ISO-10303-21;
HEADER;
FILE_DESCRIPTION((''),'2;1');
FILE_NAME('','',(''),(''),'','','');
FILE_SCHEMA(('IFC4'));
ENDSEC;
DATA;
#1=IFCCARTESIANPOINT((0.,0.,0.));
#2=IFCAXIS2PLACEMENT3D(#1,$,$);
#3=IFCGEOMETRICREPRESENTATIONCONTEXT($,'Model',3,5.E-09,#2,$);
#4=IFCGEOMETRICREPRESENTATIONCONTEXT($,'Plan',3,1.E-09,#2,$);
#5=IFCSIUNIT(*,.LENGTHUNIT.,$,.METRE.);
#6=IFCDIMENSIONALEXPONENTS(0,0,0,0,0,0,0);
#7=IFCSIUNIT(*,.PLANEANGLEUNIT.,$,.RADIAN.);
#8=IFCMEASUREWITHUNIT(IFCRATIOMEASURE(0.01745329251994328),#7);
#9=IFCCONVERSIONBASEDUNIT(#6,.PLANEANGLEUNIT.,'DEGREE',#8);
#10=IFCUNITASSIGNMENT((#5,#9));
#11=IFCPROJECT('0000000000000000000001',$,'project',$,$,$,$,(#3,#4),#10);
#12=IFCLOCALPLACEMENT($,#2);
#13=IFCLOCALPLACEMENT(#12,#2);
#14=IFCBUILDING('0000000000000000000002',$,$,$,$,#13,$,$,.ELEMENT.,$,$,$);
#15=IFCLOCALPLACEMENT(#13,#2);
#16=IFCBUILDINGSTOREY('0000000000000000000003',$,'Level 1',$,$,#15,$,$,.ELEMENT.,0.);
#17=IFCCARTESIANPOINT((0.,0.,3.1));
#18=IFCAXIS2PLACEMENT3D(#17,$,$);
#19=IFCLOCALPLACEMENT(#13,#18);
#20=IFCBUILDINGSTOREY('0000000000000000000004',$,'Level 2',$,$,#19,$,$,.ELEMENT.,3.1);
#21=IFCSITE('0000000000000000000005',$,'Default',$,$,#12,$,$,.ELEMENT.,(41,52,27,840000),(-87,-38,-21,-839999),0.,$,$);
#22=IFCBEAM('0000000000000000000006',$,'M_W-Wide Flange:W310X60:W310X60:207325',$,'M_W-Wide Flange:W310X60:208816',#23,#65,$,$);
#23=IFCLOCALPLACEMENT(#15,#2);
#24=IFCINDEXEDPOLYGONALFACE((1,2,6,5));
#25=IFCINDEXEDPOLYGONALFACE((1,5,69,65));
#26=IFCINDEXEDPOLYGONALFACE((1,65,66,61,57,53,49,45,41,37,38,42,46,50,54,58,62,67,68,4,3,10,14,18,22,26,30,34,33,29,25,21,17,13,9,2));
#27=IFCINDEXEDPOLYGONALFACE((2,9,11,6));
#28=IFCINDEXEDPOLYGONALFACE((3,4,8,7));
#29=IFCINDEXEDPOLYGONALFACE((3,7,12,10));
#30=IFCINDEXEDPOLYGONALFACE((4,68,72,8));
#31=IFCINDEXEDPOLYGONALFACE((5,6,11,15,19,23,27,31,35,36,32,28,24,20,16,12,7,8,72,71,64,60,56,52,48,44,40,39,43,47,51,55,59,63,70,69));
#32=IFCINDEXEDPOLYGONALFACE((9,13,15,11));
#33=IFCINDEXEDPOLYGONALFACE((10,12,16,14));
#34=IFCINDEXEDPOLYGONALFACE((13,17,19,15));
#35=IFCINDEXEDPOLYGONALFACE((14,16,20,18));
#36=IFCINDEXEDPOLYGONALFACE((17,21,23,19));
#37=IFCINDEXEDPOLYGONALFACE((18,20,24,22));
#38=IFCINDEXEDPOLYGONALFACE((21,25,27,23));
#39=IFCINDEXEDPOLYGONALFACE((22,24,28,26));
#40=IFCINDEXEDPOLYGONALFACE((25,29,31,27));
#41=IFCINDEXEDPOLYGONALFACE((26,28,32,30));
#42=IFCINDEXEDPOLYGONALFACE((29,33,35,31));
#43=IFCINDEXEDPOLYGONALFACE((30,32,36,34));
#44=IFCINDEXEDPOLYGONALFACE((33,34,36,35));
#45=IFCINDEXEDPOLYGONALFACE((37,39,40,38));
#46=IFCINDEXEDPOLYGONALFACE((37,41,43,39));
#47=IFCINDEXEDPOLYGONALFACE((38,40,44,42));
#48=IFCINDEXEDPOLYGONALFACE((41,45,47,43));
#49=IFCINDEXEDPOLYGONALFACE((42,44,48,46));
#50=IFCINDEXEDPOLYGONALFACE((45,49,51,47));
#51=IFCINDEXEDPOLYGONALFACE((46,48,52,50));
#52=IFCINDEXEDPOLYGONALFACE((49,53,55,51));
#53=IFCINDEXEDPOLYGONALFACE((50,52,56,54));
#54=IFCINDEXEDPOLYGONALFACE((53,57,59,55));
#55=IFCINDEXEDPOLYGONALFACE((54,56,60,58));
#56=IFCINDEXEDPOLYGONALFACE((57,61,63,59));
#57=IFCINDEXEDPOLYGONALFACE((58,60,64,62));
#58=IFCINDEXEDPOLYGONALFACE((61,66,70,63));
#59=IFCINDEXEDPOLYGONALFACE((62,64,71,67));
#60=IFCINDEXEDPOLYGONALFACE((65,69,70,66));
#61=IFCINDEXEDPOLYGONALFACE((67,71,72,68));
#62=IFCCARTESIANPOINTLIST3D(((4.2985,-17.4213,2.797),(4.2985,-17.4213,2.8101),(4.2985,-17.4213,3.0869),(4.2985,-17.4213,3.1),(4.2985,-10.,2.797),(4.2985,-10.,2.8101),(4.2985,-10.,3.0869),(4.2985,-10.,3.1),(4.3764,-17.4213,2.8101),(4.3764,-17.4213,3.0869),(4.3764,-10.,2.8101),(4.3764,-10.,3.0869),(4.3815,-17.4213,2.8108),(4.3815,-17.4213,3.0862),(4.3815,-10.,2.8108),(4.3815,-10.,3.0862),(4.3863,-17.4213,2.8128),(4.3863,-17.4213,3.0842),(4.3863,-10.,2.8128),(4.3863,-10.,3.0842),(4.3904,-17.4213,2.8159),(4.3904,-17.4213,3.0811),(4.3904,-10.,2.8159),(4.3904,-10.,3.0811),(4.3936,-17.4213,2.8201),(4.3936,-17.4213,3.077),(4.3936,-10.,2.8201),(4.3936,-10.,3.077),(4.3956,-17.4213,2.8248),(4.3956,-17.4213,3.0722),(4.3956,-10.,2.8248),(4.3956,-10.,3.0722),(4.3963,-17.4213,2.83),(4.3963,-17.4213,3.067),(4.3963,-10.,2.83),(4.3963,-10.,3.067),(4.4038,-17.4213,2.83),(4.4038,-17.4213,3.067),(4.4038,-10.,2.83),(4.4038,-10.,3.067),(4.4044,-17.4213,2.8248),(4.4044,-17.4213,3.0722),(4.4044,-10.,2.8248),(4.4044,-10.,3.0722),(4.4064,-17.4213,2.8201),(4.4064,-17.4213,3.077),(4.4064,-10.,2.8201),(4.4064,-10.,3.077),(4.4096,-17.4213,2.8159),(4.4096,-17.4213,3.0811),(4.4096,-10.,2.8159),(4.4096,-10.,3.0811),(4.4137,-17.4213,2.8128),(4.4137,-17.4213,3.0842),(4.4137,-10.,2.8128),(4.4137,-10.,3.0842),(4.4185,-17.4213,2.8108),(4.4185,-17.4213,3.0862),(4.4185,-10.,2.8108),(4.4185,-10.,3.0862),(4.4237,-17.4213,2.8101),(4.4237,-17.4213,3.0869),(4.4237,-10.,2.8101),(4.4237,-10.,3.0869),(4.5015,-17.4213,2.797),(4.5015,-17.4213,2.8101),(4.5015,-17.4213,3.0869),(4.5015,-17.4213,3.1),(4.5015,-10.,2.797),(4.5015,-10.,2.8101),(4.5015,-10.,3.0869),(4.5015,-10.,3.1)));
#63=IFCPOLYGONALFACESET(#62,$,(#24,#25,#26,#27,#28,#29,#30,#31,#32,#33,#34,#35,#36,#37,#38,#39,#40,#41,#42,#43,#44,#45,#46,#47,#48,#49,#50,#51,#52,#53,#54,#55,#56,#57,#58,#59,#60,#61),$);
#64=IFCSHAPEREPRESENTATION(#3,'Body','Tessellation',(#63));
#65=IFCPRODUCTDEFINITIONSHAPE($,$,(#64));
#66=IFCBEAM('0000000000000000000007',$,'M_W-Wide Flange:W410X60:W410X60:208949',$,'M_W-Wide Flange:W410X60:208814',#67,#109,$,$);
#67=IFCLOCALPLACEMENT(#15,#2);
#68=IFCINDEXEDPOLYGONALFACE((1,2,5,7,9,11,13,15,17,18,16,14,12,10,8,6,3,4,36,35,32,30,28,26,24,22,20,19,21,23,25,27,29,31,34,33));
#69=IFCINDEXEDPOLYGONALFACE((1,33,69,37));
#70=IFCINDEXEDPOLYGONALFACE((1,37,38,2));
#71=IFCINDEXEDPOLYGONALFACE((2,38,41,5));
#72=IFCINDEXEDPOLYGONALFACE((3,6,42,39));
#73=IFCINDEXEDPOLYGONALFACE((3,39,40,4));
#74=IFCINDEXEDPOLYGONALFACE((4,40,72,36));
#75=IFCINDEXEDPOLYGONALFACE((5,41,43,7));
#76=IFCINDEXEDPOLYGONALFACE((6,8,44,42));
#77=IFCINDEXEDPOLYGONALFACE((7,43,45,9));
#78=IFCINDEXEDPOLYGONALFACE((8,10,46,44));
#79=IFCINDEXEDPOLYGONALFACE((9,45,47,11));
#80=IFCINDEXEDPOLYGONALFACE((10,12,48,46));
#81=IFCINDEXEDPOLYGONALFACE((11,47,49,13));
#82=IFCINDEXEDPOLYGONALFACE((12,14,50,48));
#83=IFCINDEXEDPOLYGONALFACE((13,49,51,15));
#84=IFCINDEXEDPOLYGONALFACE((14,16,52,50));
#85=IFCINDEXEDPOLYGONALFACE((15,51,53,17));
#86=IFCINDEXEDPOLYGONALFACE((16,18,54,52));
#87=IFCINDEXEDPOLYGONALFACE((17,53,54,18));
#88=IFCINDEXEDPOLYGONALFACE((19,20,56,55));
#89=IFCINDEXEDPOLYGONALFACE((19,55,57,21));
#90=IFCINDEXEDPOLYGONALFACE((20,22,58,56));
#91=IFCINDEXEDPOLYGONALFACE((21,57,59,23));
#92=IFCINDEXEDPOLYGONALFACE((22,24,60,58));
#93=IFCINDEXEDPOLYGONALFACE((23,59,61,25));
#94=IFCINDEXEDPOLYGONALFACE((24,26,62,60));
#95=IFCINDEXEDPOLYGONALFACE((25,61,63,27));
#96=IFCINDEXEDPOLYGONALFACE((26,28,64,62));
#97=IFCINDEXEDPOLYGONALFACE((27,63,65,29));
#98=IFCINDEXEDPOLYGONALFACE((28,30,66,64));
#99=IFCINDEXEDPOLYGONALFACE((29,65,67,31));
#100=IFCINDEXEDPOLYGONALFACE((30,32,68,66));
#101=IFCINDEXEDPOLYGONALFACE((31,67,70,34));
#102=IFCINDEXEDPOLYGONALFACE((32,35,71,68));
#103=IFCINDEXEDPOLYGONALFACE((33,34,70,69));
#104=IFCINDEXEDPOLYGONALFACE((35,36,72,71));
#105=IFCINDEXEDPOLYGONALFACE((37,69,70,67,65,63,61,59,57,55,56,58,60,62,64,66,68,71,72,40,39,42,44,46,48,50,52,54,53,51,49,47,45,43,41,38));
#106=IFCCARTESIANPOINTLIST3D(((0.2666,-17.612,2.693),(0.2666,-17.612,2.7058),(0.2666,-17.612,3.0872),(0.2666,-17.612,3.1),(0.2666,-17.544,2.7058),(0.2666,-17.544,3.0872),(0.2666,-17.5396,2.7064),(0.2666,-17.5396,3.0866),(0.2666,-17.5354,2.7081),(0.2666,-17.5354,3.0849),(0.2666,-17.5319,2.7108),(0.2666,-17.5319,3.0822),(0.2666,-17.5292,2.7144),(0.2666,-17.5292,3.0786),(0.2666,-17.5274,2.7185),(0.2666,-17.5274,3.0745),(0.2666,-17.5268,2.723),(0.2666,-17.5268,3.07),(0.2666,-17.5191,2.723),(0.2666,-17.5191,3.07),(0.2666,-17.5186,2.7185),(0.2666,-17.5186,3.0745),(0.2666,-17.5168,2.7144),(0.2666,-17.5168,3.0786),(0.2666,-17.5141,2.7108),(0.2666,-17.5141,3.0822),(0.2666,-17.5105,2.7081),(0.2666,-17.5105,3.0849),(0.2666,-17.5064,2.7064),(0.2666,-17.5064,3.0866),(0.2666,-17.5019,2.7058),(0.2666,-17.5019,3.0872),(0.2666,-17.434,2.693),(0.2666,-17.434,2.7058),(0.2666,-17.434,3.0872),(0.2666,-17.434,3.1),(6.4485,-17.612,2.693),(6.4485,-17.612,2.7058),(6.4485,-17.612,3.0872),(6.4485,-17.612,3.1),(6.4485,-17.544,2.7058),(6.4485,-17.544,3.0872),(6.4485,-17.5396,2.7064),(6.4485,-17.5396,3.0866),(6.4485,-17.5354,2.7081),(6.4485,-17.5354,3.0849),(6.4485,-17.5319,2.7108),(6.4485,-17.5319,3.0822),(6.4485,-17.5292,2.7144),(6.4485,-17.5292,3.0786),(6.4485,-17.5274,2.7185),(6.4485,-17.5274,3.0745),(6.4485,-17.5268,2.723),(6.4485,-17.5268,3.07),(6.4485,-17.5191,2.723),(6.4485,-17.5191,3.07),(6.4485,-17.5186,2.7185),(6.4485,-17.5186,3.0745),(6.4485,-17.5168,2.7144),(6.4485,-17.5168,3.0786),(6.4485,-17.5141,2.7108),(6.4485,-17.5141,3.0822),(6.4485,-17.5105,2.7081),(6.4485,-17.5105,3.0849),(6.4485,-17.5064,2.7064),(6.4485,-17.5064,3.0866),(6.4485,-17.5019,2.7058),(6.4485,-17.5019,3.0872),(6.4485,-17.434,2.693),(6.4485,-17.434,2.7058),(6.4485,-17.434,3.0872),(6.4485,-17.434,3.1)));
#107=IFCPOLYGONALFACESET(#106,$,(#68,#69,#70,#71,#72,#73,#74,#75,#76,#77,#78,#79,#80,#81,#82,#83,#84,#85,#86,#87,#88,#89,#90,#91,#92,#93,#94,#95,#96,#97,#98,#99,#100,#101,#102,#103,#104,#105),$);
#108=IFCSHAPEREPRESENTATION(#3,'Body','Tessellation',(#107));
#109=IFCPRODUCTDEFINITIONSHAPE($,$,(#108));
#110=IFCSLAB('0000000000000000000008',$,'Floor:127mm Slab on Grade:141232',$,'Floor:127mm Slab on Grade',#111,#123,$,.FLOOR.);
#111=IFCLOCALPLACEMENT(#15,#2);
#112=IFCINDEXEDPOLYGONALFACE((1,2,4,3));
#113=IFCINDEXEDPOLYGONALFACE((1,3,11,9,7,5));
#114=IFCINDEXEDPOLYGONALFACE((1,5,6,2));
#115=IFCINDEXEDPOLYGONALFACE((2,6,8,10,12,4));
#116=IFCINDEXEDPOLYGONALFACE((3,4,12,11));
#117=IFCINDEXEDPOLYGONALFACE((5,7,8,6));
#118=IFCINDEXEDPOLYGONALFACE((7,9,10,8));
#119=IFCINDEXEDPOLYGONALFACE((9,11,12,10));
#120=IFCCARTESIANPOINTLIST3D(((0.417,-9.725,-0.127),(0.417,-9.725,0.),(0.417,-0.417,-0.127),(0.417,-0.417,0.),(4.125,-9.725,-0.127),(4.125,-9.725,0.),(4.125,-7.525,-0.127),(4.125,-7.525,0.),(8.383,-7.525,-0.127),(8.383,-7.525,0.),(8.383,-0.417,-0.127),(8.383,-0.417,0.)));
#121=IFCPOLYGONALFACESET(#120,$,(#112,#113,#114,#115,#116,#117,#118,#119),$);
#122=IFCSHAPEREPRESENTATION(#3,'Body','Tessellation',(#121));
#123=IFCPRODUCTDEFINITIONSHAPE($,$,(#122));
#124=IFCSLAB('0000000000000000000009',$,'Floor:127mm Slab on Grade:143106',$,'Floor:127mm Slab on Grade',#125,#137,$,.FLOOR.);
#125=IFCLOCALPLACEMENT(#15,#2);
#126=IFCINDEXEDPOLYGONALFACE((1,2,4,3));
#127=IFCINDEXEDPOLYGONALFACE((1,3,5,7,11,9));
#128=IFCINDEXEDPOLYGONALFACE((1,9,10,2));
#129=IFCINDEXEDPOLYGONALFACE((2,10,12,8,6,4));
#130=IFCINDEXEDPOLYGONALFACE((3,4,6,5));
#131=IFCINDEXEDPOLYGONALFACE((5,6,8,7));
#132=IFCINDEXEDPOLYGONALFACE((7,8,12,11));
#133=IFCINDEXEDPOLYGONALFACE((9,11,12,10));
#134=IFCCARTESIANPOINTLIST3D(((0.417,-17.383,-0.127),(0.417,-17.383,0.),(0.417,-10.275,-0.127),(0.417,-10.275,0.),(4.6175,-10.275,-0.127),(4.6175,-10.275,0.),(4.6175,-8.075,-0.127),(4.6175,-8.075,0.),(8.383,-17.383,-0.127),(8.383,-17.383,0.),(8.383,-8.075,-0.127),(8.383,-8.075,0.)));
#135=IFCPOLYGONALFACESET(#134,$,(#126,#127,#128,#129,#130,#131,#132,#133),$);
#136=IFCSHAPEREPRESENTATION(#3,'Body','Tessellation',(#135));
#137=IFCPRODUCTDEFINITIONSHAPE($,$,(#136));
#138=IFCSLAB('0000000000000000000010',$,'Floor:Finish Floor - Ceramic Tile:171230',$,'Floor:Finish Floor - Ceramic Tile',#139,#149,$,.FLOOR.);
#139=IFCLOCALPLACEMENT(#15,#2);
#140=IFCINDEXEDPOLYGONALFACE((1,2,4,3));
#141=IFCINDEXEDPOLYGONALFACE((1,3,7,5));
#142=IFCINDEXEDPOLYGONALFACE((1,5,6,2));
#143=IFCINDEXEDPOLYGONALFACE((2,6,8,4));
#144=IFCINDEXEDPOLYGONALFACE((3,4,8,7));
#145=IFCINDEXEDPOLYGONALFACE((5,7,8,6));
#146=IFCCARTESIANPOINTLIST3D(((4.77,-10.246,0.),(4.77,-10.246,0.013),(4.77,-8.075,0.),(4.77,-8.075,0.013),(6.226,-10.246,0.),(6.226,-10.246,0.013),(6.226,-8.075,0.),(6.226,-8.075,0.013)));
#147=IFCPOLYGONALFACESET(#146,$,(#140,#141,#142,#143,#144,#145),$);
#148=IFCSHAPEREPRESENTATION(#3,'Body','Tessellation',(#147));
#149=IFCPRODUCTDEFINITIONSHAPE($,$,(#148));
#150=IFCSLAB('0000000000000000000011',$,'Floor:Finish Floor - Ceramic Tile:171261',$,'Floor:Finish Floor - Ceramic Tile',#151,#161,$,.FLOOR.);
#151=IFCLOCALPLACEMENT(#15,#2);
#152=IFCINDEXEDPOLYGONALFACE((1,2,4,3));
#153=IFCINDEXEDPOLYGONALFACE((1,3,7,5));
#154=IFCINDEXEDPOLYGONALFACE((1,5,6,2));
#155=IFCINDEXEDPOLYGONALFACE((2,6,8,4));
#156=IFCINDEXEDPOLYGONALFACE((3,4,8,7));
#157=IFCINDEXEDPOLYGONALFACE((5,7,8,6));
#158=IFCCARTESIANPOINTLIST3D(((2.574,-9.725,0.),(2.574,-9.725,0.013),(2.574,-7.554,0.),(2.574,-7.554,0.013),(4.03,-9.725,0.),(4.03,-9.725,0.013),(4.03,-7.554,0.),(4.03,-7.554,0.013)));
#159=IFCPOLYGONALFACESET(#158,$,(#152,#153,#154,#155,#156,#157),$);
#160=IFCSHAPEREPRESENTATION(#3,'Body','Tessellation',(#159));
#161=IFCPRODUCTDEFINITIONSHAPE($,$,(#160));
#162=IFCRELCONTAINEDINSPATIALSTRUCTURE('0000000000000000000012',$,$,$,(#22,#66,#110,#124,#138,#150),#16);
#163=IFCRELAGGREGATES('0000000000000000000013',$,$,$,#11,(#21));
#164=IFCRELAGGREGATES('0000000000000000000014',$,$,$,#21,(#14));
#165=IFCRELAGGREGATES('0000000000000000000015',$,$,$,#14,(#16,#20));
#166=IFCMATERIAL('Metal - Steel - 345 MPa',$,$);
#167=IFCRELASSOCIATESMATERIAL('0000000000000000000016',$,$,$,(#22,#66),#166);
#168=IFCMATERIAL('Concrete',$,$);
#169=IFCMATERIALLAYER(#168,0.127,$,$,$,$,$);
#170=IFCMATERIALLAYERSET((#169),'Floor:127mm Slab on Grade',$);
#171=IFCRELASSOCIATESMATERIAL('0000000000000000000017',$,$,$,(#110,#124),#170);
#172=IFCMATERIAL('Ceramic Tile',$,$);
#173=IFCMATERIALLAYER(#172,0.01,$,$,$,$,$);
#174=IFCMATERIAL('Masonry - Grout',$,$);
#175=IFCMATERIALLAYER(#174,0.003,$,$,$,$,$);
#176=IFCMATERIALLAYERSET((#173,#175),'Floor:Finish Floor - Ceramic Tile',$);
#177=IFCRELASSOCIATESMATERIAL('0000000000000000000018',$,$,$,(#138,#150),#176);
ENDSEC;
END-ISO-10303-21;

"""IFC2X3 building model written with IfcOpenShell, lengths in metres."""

from ifc_helpers import new_model, entity, si_unit, converted_unit, frame, frame_2d, origin, place, context, project, spatial, polyline, circle_curve, parameter, trimmed, segment, composite_curve, rectangle, outline, extrude, material, layer, layer_set, layer_usage, element, save


model = new_model("IFC2X3")

# Units and contexts
model_context = context("Model", 3, precision=5e-09, world=origin())
plan_context = context("Plan", 3, precision=1e-09, world=origin())
ifc_project = project(units=[si_unit("LENGTHUNIT", "METRE"), converted_unit("PLANEANGLEUNIT", "DEGREE", entity("IfcRatioMeasure", 0.01745329251994328), si_unit("PLANEANGLEUNIT", "RADIAN"), dimensions=[0, 0, 0, 0, 0, 0, 0])], contexts=[model_context, plan_context])

# Site, building, storey
site_placement = place(None, origin())
site = spatial("IfcSite", under=ifc_project, at=site_placement, Name="Default", CompositionType="ELEMENT", RefLatitude=(41, 52, 27, 840000), RefLongitude=(-87, -38, -21, -839999), RefElevation=0.0)
building_placement = place(site_placement, origin())
building = spatial("IfcBuilding", under=site, at=building_placement, CompositionType="ELEMENT")
storey_1_placement = place(building_placement, origin())
storey_1 = spatial("IfcBuildingStorey", under=building, at=storey_1_placement, Name="Level 1", CompositionType="ELEMENT", Elevation=0.0)

# Beams
ifc_material_1 = material(Name="Metal - Steel - 345 MPa")
beam_1_placement = place(storey_1_placement, frame((4.4, -10.0, 3.1), z_axis=(0.0, 0.0, 1.0), x_axis=(-1.0, 0.0, 0.0)))
element("IfcBeam", 1, at=beam_1_placement, inside=storey_1, material=ifc_material_1, Name="M_W-Wide Flange:W310X60:W310X60:207325", ObjectType="M_W-Wide Flange:W310X60:208816", context=model_context, shape_type="SweptSolid", body=[
    extrude(outline(composite_curve([segment(polyline([(0.1384, -0.1015), (0.1515, -0.1015)]), True, "CONTINUOUS"), segment(polyline([(0.1515, -0.1015), (0.1515, 0.1015)]), True, "CONTINUOUS"), segment(polyline([(0.1515, 0.1015), (0.1384, 0.1015)]), True, "CONTINUOUS"), segment(polyline([(0.1384, 0.1015), (0.1384, 0.0236)]), True, "CONTINUOUS"), segment(trimmed(circle_curve(frame_2d((0.1185, 0.0236), x_axis=(0.0, 1.0)), 0.0199), [parameter(180.0)], [parameter(270.0)], True, "PARAMETER"), False, "CONTINUOUS"), segment(polyline([(0.1185, 0.0037), (-0.1185, 0.0037)]), True, "CONTINUOUS"), segment(trimmed(circle_curve(frame_2d((-0.1185, 0.0236), x_axis=(0.0, 1.0)), 0.0199), [parameter(90.0)], [parameter(180.0)], True, "PARAMETER"), False, "CONTINUOUS"), segment(polyline([(-0.1384, 0.0236), (-0.1384, 0.1015)]), True, "CONTINUOUS"), segment(polyline([(-0.1384, 0.1015), (-0.1515, 0.1015)]), True, "CONTINUOUS"), segment(polyline([(-0.1515, 0.1015), (-0.1515, -0.1015)]), True, "CONTINUOUS"), segment(polyline([(-0.1515, -0.1015), (-0.1384, -0.1015)]), True, "CONTINUOUS"), segment(polyline([(-0.1384, -0.1015), (-0.1384, -0.0237)]), True, "CONTINUOUS"), segment(trimmed(circle_curve(frame_2d((-0.1185, -0.0237), x_axis=(0.0, 1.0)), 0.0199), [parameter(360.0)], [parameter(90.0)], True, "PARAMETER"), False, "CONTINUOUS"), segment(polyline([(-0.1185, -0.0038), (0.1185, -0.0038)]), True, "CONTINUOUS"), segment(trimmed(circle_curve(frame_2d((0.1185, -0.0237), x_axis=(0.0, 1.0)), 0.0199), [parameter(270.0)], [parameter(0.0)], True, "PARAMETER"), False, "CONTINUOUS"), segment(polyline([(0.1384, -0.0237), (0.1384, -0.1015)]), True, "CONTINUOUS")], self_intersect=False)), frame((0.0, 7.4213, -0.1515), z_axis=(0.0, -1.0, 0.0), x_axis=(0.0, 0.0, -1.0)), (0.0, 0.0, 1.0), 7.4213),
])
beam_2_placement = place(storey_1_placement, frame((0.2085, -17.523, 3.1), z_axis=(0.0, 0.0, 1.0), x_axis=(0.0, -1.0, 0.0)))
element("IfcBeam", 2, at=beam_2_placement, inside=storey_1, material=ifc_material_1, Name="M_W-Wide Flange:W410X60:W410X60:208949", ObjectType="M_W-Wide Flange:W410X60:208814", context=model_context, shape_type="SweptSolid", body=[
    extrude(outline(composite_curve([segment(polyline([(-0.089, -0.1907), (-0.089, -0.2035)]), True, "CONTINUOUS"), segment(polyline([(-0.089, -0.2035), (0.089, -0.2035)]), True, "CONTINUOUS"), segment(polyline([(0.089, -0.2035), (0.089, -0.1907)]), True, "CONTINUOUS"), segment(polyline([(0.089, -0.1907), (0.021, -0.1907)]), True, "CONTINUOUS"), segment(trimmed(circle_curve(frame_2d((0.021, -0.1735), x_axis=(0.0, -1.0)), 0.0172), [parameter(270.0)], [parameter(360.0)], True, "PARAMETER"), False, "CONTINUOUS"), segment(polyline([(0.0038, -0.1735), (0.0038, 0.1735)]), True, "CONTINUOUS"), segment(trimmed(circle_curve(frame_2d((0.021, 0.1735), x_axis=(-1.0, 0.0)), 0.0172), [parameter(270.0)], [parameter(360.0)], True, "PARAMETER"), False, "CONTINUOUS"), segment(polyline([(0.021, 0.1907), (0.089, 0.1907)]), True, "CONTINUOUS"), segment(polyline([(0.089, 0.1907), (0.089, 0.2035)]), True, "CONTINUOUS"), segment(polyline([(0.089, 0.2035), (-0.089, 0.2035)]), True, "CONTINUOUS"), segment(polyline([(-0.089, 0.2035), (-0.089, 0.1907)]), True, "CONTINUOUS"), segment(polyline([(-0.089, 0.1907), (-0.0211, 0.1907)]), True, "CONTINUOUS"), segment(trimmed(circle_curve(frame_2d((-0.0211, 0.1735), x_axis=(0.0, 1.0)), 0.0172), [parameter(270.0)], [parameter(0.0)], True, "PARAMETER"), False, "CONTINUOUS"), segment(polyline([(-0.0039, 0.1735), (-0.0039, -0.1735)]), True, "CONTINUOUS"), segment(trimmed(circle_curve(frame_2d((-0.0211, -0.1735), x_axis=(1.0, 0.0)), 0.0172), [parameter(270.0)], [parameter(0.0)], True, "PARAMETER"), False, "CONTINUOUS"), segment(polyline([(-0.0211, -0.1907), (-0.089, -0.1907)]), True, "CONTINUOUS")], self_intersect=False)), frame((0.0, 0.0581, -0.2035), z_axis=(0.0, -1.0, 0.0), x_axis=(1.0, 0.0, 0.0)), (0.0, 0.0, -1.0), 6.1819),
])

# Slabs
ifc_material_2 = material(Name="Concrete")
ifc_layer_1 = layer(ifc_material_2, 0.127)
ifc_layer_set_1 = layer_set([ifc_layer_1], Name="Floor:127mm Slab on Grade")
ifc_layer_usage_1 = layer_usage(ifc_layer_set_1, "AXIS3", "POSITIVE", 0.0)
slab_1_placement = place(storey_1_placement, frame((0.417, -9.725, -0.127)))
element("IfcSlab", 3, at=slab_1_placement, inside=storey_1, material=ifc_layer_usage_1, Name="Floor:127mm Slab on Grade:141232", ObjectType="Floor:127mm Slab on Grade", PredefinedType="FLOOR", context=model_context, shape_type="SweptSolid", body=[
    extrude(outline(polyline([(-3.983, 4.654), (-3.983, -2.454), (0.275, -2.454), (0.275, -4.654), (3.983, -4.654), (3.983, 4.654), (-3.983, 4.654)])), frame((3.983, 4.654, 0.127), z_axis=(0.0, 0.0, -1.0), x_axis=(-1.0, 0.0, 0.0)), (0.0, 0.0, 1.0), 0.127),
])
slab_2_placement = place(storey_1_placement, frame((0.417, -17.383, -0.127)))
element("IfcSlab", 4, at=slab_2_placement, inside=storey_1, material=ifc_layer_usage_1, Name="Floor:127mm Slab on Grade:143106", ObjectType="Floor:127mm Slab on Grade", PredefinedType="FLOOR", context=model_context, shape_type="SweptSolid", body=[
    extrude(outline(polyline([(-3.983, 4.654), (-3.983, -4.654), (3.983, -4.654), (3.983, 2.454), (-0.2175, 2.454), (-0.2175, 4.654), (-3.983, 4.654)])), frame((3.983, 4.654, 0.127), z_axis=(0.0, 0.0, -1.0), x_axis=(-1.0, 0.0, 0.0)), (0.0, 0.0, 1.0), 0.127),
])
ifc_material_3 = material(Name="Ceramic Tile")
ifc_layer_2 = layer(ifc_material_3, 0.01)
ifc_material_4 = material(Name="Masonry - Grout")
ifc_layer_3 = layer(ifc_material_4, 0.003)
ifc_layer_set_2 = layer_set([ifc_layer_2, ifc_layer_3], Name="Floor:Finish Floor - Ceramic Tile")
ifc_layer_usage_2 = layer_usage(ifc_layer_set_2, "AXIS3", "POSITIVE", 0.0)
slab_3_placement = place(storey_1_placement, frame((4.77, -10.246, 0.0)))
element("IfcSlab", 5, at=slab_3_placement, inside=storey_1, material=ifc_layer_usage_2, Name="Floor:Finish Floor - Ceramic Tile:171230", ObjectType="Floor:Finish Floor - Ceramic Tile", PredefinedType="FLOOR", context=model_context, shape_type="SweptSolid", body=[
    extrude(rectangle(XDim=1.456, YDim=2.171, at=frame_2d((0.0, 0.0), x_axis=(-1.0, 0.0))), frame((0.728, 1.0855, 0.013), z_axis=(0.0, 0.0, -1.0), x_axis=(-1.0, 0.0, 0.0)), (0.0, 0.0, 1.0), 0.013),
])
slab_4_placement = place(storey_1_placement, frame((2.574, -9.725, 0.0)))
element("IfcSlab", 6, at=slab_4_placement, inside=storey_1, material=ifc_layer_usage_2, Name="Floor:Finish Floor - Ceramic Tile:171261", ObjectType="Floor:Finish Floor - Ceramic Tile", PredefinedType="FLOOR", context=model_context, shape_type="SweptSolid", body=[
    extrude(rectangle(XDim=2.171, YDim=1.456, at=frame_2d((0.0, 0.0), x_axis=(0.0, -1.0))), frame((0.728, 1.0855, 0.013), z_axis=(0.0, 0.0, -1.0), x_axis=(-1.0, 0.0, 0.0)), (0.0, 0.0, 1.0), 0.013),
])

# Shared definitions
storey_2_placement = place(building_placement, frame((0.0, 0.0, 3.1)))
storey_2 = spatial("IfcBuildingStorey", under=building, at=storey_2_placement, Name="Level 2", CompositionType="ELEMENT", Elevation=3.1)

save(model, "model.ifc")
